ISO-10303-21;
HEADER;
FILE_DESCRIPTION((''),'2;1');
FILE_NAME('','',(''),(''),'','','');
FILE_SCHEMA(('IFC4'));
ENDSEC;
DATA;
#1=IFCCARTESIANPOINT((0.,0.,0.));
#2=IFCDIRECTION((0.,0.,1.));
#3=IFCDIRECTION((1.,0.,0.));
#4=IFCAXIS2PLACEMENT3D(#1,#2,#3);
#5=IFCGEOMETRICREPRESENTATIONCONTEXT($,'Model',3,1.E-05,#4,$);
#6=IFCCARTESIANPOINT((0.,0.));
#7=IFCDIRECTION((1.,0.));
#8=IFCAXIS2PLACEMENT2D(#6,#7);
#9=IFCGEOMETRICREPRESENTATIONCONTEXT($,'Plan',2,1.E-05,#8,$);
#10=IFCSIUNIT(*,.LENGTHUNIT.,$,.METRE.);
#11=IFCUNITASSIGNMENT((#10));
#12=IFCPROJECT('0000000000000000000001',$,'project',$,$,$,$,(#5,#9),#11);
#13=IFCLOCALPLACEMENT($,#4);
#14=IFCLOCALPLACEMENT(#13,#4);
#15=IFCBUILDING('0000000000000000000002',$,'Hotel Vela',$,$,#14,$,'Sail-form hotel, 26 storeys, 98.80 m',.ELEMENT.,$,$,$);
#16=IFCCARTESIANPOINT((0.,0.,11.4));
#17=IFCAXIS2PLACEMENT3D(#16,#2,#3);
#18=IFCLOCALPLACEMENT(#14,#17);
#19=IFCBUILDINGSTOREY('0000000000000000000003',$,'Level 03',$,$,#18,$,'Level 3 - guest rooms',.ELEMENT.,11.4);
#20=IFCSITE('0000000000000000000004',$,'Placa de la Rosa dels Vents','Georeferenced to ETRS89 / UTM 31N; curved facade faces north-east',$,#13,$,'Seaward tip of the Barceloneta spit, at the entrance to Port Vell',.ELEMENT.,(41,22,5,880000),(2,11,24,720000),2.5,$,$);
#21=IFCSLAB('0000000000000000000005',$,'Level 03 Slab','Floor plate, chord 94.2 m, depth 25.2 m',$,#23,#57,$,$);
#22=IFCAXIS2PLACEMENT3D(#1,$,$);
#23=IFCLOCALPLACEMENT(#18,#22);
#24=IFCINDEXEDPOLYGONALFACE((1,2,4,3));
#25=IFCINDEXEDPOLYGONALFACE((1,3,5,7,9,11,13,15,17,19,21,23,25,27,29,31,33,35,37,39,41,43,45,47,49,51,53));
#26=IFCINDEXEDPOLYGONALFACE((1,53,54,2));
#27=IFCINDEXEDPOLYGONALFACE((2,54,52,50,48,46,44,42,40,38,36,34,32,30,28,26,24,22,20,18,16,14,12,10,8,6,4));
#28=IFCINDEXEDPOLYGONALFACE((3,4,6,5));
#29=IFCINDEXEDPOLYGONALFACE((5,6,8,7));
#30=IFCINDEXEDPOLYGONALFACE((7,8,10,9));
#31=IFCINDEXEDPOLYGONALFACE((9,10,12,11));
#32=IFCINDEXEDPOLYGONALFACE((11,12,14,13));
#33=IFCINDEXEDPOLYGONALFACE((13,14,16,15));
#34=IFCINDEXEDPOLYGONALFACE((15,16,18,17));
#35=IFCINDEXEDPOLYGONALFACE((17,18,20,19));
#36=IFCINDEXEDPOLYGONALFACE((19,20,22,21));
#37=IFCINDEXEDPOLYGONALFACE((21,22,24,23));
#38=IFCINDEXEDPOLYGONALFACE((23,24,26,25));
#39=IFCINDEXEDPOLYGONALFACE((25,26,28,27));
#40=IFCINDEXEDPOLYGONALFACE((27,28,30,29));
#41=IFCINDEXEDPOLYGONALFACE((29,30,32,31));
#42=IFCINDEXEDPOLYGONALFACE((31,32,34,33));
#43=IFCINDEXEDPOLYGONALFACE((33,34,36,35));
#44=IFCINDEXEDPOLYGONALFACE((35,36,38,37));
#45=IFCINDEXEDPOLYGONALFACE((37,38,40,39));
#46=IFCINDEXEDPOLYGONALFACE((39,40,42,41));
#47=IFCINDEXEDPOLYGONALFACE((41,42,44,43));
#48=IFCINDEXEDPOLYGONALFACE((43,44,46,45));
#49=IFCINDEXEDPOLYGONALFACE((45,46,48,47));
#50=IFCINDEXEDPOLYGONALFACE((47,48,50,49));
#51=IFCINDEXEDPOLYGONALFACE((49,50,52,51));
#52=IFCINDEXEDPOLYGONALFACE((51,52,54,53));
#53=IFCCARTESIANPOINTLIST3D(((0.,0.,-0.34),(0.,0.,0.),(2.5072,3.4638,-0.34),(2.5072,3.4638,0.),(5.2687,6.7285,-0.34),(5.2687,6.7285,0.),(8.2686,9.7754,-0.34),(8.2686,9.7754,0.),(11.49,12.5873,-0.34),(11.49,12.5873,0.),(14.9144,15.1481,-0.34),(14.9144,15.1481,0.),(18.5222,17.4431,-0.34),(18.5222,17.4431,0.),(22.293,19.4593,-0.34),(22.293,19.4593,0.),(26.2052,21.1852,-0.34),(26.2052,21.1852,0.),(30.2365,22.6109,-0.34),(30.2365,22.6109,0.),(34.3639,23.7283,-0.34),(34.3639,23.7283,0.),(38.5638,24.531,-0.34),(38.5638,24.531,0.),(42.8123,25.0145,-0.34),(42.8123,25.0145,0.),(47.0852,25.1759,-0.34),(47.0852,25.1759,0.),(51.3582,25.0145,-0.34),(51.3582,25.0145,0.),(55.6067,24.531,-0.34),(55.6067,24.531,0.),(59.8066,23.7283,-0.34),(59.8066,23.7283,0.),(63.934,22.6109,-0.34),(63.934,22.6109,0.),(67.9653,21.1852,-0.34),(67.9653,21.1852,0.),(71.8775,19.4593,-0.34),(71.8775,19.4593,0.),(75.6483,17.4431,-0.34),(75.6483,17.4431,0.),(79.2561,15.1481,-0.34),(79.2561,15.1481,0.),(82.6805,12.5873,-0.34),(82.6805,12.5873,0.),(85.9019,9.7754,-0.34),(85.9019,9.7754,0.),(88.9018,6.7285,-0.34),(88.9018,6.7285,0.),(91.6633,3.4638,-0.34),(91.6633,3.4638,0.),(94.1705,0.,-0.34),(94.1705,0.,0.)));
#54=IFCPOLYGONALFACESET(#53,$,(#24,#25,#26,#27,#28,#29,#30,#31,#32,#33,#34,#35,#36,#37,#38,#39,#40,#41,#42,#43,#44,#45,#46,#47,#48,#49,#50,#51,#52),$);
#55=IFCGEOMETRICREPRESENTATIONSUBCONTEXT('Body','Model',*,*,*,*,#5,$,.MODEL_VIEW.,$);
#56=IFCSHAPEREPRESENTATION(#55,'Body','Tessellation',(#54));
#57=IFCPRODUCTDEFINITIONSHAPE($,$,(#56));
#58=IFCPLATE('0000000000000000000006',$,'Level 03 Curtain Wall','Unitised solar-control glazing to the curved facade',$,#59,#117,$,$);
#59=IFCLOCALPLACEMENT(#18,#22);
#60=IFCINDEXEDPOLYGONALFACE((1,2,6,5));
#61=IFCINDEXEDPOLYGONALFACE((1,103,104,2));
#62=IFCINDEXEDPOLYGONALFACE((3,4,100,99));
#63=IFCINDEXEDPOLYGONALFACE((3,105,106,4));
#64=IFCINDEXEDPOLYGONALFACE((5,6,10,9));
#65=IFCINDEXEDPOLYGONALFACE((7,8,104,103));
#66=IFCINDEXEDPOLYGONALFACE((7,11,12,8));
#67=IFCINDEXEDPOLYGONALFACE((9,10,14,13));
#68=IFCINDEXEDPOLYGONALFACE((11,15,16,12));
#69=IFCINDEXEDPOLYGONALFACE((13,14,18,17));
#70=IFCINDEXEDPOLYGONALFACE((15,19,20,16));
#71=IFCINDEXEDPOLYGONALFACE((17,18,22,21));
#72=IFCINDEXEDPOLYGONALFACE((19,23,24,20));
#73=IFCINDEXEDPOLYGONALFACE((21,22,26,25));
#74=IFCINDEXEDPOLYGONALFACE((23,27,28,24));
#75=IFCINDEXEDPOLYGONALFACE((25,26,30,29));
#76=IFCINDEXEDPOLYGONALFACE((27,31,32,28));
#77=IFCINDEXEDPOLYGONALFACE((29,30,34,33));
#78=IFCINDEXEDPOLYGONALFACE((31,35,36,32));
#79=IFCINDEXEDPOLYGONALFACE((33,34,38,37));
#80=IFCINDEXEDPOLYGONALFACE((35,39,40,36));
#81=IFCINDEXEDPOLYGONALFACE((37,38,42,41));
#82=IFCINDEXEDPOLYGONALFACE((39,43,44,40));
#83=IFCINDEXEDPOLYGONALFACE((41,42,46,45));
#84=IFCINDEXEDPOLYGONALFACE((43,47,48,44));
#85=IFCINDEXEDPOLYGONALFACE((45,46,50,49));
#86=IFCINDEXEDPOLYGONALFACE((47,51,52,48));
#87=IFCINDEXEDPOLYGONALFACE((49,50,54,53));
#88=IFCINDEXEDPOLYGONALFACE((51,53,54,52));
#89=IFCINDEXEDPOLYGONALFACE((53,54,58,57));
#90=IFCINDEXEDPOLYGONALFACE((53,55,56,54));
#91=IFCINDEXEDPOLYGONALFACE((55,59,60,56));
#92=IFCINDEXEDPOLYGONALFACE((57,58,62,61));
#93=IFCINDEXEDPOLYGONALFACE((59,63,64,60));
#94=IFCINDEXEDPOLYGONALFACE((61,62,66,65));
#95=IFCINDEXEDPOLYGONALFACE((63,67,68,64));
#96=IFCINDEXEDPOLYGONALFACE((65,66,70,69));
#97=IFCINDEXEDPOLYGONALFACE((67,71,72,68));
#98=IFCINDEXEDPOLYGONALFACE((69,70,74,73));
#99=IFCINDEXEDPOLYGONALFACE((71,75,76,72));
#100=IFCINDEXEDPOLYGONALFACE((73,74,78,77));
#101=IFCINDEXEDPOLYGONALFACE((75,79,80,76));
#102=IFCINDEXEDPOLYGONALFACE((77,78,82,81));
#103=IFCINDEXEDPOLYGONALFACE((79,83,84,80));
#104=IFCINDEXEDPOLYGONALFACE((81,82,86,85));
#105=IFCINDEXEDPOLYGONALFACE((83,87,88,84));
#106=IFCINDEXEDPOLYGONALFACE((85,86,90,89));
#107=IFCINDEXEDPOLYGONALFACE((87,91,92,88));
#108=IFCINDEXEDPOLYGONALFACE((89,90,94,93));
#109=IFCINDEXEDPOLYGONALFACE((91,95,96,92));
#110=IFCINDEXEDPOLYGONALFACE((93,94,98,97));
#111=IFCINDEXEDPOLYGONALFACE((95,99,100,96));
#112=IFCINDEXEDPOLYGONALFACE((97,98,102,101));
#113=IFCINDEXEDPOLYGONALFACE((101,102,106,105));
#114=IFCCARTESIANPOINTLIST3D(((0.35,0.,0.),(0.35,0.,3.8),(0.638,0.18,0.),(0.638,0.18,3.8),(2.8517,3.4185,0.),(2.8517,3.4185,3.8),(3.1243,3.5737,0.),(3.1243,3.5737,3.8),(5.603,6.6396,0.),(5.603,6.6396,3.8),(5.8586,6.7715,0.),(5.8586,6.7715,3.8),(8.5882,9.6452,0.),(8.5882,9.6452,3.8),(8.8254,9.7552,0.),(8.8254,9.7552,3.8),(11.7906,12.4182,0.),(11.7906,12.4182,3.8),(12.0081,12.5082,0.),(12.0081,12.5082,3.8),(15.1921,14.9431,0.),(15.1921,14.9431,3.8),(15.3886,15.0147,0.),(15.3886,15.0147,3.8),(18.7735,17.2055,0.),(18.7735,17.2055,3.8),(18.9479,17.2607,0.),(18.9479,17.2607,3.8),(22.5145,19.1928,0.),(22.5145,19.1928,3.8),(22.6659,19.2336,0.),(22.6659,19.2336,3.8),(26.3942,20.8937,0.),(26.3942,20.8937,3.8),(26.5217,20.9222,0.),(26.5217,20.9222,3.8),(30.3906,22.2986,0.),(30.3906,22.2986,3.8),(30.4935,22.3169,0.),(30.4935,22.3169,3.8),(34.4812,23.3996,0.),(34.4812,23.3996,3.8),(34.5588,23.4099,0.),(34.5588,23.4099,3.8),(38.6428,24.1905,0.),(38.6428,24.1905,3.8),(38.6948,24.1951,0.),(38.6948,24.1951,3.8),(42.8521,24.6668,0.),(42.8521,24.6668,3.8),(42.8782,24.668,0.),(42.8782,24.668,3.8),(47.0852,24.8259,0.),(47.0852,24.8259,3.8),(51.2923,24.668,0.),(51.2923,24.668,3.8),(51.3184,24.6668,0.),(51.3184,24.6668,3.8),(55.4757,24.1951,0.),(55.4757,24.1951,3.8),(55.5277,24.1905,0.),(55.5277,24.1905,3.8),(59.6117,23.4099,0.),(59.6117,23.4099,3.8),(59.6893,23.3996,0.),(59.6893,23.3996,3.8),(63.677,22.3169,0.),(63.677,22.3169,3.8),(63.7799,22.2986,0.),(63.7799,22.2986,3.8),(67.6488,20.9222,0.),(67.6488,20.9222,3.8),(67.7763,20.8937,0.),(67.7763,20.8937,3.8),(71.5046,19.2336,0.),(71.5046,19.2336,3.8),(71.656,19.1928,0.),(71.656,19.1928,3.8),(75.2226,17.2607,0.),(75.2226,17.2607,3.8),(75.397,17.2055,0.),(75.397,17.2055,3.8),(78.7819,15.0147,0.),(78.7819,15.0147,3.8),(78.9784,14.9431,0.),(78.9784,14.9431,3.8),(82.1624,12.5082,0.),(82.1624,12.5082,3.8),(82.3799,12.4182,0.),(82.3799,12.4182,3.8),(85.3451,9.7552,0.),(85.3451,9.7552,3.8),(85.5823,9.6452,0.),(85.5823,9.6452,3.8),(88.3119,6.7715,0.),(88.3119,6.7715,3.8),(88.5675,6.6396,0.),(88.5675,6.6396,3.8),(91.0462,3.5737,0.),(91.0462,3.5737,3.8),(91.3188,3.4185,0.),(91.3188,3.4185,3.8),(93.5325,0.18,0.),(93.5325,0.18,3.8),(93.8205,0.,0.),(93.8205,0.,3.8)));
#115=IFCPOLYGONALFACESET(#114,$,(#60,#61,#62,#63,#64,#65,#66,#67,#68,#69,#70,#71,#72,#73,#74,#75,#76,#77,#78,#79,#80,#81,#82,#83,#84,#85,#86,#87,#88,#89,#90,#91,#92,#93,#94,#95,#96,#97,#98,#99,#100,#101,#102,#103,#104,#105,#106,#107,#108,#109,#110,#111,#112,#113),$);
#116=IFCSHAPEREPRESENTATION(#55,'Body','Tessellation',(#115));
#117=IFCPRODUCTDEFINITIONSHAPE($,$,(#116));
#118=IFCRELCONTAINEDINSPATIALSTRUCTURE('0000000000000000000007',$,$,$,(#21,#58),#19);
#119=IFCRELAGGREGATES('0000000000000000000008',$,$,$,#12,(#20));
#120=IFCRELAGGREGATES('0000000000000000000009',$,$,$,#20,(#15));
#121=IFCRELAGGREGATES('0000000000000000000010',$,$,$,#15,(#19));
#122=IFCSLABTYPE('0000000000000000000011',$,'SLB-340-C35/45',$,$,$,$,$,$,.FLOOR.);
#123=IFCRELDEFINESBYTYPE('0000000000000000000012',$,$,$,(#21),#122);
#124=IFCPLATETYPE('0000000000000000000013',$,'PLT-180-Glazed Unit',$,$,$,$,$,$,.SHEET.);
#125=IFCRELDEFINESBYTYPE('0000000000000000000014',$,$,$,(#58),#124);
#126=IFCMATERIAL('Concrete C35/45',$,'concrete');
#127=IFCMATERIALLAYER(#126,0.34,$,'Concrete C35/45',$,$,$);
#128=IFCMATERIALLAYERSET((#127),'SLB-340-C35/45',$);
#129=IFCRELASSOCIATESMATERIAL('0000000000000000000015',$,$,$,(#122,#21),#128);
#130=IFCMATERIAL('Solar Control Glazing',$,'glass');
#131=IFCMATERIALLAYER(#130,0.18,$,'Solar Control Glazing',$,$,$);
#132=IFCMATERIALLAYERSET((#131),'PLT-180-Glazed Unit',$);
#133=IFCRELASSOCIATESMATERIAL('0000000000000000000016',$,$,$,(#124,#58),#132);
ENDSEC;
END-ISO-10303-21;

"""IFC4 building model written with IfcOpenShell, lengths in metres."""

from ifc_helpers import new_model, si_unit, frame, origin_with_axes, origin_2d_with_axis, place, context, subcontext, project, spatial, line, indexed_curve, outline, extrude, material, layer, layer_set, layer_usage, type_object, element, save


model = new_model("IFC4")

# Units and contexts
model_context = context("Model", 3, precision=1e-05, world=origin_with_axes())
plan_context = context("Plan", 2, precision=1e-05, world=origin_2d_with_axis())
body_context = subcontext(model_context, "Body", "Model", "MODEL_VIEW")
ifc_project = project(units=[si_unit("LENGTHUNIT", "METRE")], contexts=[model_context, plan_context])

# Site, building, storey
site_placement = place(None, origin_with_axes())
site = spatial("IfcSite", under=ifc_project, at=site_placement, Name="Placa de la Rosa dels Vents", Description="Georeferenced to ETRS89 / UTM 31N; curved facade faces north-east", LongName="Seaward tip of the Barceloneta spit, at the entrance to Port Vell", CompositionType="ELEMENT", RefLatitude=(41, 22, 5, 880000), RefLongitude=(2, 11, 24, 720000), RefElevation=2.5)
building_placement = place(site_placement, origin_with_axes())
building = spatial("IfcBuilding", under=site, at=building_placement, Name="Hotel Vela", LongName="Sail-form hotel, 26 storeys, 98.80 m", CompositionType="ELEMENT")
storey_placement = place(building_placement, frame((0.0, 0.0, 11.4), z_axis=(0.0, 0.0, 1.0), x_axis=(1.0, 0.0, 0.0)))
storey = spatial("IfcBuildingStorey", under=building, at=storey_placement, Name="Level 03", LongName="Level 3 - guest rooms", CompositionType="ELEMENT", Elevation=11.4)

# Slab
ifc_material_1 = material(Name="Concrete C35/45", Category="concrete")
ifc_layer_1 = layer(ifc_material_1, 0.34, Name="Concrete C35/45")
ifc_layer_set_1 = layer_set([ifc_layer_1], Name="SLB-340-C35/45")
ifc_layer_usage_1 = layer_usage(ifc_layer_set_1, "AXIS3", "POSITIVE", 0.0)
slab_type = type_object("IfcSlabType", Name="SLB-340-C35/45", PredefinedType="FLOOR", material=ifc_layer_set_1)
slab_placement = place(storey_placement, frame((0.0, 0.0, -0.34), z_axis=(0.0, 0.0, 1.0), x_axis=(1.0, 0.0, 0.0)))
element("IfcSlab", 1, at=slab_placement, inside=storey, type_object=slab_type, material=ifc_layer_usage_1, Name="Level 03 Slab", Description="Floor plate, chord 94.2 m, depth 25.2 m", context=body_context, shape_type="SweptSolid", body=[
    extrude(outline(indexed_curve([(0.0, 0.0), (94.1705, 0.0), (91.6633, 3.4638), (88.9018, 6.7285), (85.9019, 9.7754), (82.6805, 12.5873), (79.2561, 15.1481), (75.6483, 17.4431), (71.8775, 19.4593), (67.9653, 21.1852), (63.934, 22.6109), (59.8066, 23.7283), (55.6067, 24.531), (51.3582, 25.0145), (47.0852, 25.1759), (42.8123, 25.0145), (38.5638, 24.531), (34.3639, 23.7283), (30.2365, 22.6109), (26.2052, 21.1852), (22.293, 19.4593), (18.5222, 17.4431), (14.9144, 15.1481), (11.49, 12.5873), (8.2686, 9.7754), (5.2687, 6.7285), (2.5072, 3.4638)], segments=[line(1, 2, 3, 4, 5, 6, 7, 8, 9, 10, 11, 12, 13, 14, 15, 16, 17, 18, 19, 20, 21, 22, 23, 24, 25, 26, 27, 1)])), origin_with_axes(), (0.0, 0.0, 1.0), 0.34),
])

# Plate
ifc_material_2 = material(Name="Solar Control Glazing", Category="glass")
ifc_layer_2 = layer(ifc_material_2, 0.18, Name="Solar Control Glazing")
ifc_layer_set_2 = layer_set([ifc_layer_2], Name="PLT-180-Glazed Unit")
ifc_layer_usage_2 = layer_usage(ifc_layer_set_2, "AXIS2", "POSITIVE", 0.0)
plate_type_1 = type_object("IfcPlateType", Name="PLT-180-Glazed Unit", PredefinedType="SHEET", material=ifc_layer_set_2)
plate_1_placement = place(storey_placement, frame((0.35, 0.0, 0.0), z_axis=(0.0, 0.0, 1.0), x_axis=(1.0, 0.0, 0.0)))
element("IfcPlate", 2, at=plate_1_placement, inside=storey, type_object=plate_type_1, material=ifc_layer_usage_2, Name="Level 03 Curtain Wall", Description="Unitised solar-control glazing to the curved facade", context=body_context, shape_type="SweptSolid", body=[
    extrude(outline(indexed_curve([(93.4705, 0.0), (90.9688, 3.4185), (88.2175, 6.6396), (85.2323, 9.6452), (82.0299, 12.4182), (78.6284, 14.9431), (75.047, 17.2055), (71.306, 19.1928), (67.4263, 20.8937), (63.4299, 22.2986), (59.3393, 23.3996), (55.1777, 24.1905), (50.9684, 24.6668), (46.7352, 24.8259), (42.5021, 24.6668), (38.2928, 24.1905), (34.1312, 23.3996), (30.0406, 22.2986), (26.0442, 20.8937), (22.1645, 19.1928), (18.4235, 17.2055), (14.8421, 14.9431), (11.4406, 12.4182), (8.2382, 9.6452), (5.253, 6.6396), (2.5017, 3.4185), (0.0, 0.0), (93.1825, 0.18), (2.7743, 3.5737), (5.5086, 6.7715), (8.4754, 9.7552), (11.6581, 12.5082), (15.0386, 15.0147), (18.5979, 17.2607), (22.3159, 19.2336), (26.1717, 20.9222), (30.1435, 22.3169), (34.2088, 23.4099), (38.3448, 24.1951), (42.5282, 24.668), (46.7352, 24.8259), (50.9423, 24.668), (55.1257, 24.1951), (59.2617, 23.4099), (63.327, 22.3169), (67.2988, 20.9222), (71.1546, 19.2336), (74.8726, 17.2607), (78.4319, 15.0147), (81.8124, 12.5082), (84.9951, 9.7552), (87.9619, 6.7715), (90.6962, 3.5737), (0.288, 0.18)], segments=[line(1, 2, 3, 4, 5, 6, 7, 8, 9, 10, 11, 12, 13, 14, 15, 16, 17, 18, 19, 20, 21, 22, 23, 24, 25, 26, 27, 28, 29, 30, 31, 32, 33, 34, 35, 36, 37, 38, 39, 40, 41, 42, 43, 44, 45, 46, 47, 48, 49, 50, 51, 52, 53, 54, 1)])), origin_with_axes(), (0.0, 0.0, 1.0), 3.8),
])

save(model, "model.ifc")
